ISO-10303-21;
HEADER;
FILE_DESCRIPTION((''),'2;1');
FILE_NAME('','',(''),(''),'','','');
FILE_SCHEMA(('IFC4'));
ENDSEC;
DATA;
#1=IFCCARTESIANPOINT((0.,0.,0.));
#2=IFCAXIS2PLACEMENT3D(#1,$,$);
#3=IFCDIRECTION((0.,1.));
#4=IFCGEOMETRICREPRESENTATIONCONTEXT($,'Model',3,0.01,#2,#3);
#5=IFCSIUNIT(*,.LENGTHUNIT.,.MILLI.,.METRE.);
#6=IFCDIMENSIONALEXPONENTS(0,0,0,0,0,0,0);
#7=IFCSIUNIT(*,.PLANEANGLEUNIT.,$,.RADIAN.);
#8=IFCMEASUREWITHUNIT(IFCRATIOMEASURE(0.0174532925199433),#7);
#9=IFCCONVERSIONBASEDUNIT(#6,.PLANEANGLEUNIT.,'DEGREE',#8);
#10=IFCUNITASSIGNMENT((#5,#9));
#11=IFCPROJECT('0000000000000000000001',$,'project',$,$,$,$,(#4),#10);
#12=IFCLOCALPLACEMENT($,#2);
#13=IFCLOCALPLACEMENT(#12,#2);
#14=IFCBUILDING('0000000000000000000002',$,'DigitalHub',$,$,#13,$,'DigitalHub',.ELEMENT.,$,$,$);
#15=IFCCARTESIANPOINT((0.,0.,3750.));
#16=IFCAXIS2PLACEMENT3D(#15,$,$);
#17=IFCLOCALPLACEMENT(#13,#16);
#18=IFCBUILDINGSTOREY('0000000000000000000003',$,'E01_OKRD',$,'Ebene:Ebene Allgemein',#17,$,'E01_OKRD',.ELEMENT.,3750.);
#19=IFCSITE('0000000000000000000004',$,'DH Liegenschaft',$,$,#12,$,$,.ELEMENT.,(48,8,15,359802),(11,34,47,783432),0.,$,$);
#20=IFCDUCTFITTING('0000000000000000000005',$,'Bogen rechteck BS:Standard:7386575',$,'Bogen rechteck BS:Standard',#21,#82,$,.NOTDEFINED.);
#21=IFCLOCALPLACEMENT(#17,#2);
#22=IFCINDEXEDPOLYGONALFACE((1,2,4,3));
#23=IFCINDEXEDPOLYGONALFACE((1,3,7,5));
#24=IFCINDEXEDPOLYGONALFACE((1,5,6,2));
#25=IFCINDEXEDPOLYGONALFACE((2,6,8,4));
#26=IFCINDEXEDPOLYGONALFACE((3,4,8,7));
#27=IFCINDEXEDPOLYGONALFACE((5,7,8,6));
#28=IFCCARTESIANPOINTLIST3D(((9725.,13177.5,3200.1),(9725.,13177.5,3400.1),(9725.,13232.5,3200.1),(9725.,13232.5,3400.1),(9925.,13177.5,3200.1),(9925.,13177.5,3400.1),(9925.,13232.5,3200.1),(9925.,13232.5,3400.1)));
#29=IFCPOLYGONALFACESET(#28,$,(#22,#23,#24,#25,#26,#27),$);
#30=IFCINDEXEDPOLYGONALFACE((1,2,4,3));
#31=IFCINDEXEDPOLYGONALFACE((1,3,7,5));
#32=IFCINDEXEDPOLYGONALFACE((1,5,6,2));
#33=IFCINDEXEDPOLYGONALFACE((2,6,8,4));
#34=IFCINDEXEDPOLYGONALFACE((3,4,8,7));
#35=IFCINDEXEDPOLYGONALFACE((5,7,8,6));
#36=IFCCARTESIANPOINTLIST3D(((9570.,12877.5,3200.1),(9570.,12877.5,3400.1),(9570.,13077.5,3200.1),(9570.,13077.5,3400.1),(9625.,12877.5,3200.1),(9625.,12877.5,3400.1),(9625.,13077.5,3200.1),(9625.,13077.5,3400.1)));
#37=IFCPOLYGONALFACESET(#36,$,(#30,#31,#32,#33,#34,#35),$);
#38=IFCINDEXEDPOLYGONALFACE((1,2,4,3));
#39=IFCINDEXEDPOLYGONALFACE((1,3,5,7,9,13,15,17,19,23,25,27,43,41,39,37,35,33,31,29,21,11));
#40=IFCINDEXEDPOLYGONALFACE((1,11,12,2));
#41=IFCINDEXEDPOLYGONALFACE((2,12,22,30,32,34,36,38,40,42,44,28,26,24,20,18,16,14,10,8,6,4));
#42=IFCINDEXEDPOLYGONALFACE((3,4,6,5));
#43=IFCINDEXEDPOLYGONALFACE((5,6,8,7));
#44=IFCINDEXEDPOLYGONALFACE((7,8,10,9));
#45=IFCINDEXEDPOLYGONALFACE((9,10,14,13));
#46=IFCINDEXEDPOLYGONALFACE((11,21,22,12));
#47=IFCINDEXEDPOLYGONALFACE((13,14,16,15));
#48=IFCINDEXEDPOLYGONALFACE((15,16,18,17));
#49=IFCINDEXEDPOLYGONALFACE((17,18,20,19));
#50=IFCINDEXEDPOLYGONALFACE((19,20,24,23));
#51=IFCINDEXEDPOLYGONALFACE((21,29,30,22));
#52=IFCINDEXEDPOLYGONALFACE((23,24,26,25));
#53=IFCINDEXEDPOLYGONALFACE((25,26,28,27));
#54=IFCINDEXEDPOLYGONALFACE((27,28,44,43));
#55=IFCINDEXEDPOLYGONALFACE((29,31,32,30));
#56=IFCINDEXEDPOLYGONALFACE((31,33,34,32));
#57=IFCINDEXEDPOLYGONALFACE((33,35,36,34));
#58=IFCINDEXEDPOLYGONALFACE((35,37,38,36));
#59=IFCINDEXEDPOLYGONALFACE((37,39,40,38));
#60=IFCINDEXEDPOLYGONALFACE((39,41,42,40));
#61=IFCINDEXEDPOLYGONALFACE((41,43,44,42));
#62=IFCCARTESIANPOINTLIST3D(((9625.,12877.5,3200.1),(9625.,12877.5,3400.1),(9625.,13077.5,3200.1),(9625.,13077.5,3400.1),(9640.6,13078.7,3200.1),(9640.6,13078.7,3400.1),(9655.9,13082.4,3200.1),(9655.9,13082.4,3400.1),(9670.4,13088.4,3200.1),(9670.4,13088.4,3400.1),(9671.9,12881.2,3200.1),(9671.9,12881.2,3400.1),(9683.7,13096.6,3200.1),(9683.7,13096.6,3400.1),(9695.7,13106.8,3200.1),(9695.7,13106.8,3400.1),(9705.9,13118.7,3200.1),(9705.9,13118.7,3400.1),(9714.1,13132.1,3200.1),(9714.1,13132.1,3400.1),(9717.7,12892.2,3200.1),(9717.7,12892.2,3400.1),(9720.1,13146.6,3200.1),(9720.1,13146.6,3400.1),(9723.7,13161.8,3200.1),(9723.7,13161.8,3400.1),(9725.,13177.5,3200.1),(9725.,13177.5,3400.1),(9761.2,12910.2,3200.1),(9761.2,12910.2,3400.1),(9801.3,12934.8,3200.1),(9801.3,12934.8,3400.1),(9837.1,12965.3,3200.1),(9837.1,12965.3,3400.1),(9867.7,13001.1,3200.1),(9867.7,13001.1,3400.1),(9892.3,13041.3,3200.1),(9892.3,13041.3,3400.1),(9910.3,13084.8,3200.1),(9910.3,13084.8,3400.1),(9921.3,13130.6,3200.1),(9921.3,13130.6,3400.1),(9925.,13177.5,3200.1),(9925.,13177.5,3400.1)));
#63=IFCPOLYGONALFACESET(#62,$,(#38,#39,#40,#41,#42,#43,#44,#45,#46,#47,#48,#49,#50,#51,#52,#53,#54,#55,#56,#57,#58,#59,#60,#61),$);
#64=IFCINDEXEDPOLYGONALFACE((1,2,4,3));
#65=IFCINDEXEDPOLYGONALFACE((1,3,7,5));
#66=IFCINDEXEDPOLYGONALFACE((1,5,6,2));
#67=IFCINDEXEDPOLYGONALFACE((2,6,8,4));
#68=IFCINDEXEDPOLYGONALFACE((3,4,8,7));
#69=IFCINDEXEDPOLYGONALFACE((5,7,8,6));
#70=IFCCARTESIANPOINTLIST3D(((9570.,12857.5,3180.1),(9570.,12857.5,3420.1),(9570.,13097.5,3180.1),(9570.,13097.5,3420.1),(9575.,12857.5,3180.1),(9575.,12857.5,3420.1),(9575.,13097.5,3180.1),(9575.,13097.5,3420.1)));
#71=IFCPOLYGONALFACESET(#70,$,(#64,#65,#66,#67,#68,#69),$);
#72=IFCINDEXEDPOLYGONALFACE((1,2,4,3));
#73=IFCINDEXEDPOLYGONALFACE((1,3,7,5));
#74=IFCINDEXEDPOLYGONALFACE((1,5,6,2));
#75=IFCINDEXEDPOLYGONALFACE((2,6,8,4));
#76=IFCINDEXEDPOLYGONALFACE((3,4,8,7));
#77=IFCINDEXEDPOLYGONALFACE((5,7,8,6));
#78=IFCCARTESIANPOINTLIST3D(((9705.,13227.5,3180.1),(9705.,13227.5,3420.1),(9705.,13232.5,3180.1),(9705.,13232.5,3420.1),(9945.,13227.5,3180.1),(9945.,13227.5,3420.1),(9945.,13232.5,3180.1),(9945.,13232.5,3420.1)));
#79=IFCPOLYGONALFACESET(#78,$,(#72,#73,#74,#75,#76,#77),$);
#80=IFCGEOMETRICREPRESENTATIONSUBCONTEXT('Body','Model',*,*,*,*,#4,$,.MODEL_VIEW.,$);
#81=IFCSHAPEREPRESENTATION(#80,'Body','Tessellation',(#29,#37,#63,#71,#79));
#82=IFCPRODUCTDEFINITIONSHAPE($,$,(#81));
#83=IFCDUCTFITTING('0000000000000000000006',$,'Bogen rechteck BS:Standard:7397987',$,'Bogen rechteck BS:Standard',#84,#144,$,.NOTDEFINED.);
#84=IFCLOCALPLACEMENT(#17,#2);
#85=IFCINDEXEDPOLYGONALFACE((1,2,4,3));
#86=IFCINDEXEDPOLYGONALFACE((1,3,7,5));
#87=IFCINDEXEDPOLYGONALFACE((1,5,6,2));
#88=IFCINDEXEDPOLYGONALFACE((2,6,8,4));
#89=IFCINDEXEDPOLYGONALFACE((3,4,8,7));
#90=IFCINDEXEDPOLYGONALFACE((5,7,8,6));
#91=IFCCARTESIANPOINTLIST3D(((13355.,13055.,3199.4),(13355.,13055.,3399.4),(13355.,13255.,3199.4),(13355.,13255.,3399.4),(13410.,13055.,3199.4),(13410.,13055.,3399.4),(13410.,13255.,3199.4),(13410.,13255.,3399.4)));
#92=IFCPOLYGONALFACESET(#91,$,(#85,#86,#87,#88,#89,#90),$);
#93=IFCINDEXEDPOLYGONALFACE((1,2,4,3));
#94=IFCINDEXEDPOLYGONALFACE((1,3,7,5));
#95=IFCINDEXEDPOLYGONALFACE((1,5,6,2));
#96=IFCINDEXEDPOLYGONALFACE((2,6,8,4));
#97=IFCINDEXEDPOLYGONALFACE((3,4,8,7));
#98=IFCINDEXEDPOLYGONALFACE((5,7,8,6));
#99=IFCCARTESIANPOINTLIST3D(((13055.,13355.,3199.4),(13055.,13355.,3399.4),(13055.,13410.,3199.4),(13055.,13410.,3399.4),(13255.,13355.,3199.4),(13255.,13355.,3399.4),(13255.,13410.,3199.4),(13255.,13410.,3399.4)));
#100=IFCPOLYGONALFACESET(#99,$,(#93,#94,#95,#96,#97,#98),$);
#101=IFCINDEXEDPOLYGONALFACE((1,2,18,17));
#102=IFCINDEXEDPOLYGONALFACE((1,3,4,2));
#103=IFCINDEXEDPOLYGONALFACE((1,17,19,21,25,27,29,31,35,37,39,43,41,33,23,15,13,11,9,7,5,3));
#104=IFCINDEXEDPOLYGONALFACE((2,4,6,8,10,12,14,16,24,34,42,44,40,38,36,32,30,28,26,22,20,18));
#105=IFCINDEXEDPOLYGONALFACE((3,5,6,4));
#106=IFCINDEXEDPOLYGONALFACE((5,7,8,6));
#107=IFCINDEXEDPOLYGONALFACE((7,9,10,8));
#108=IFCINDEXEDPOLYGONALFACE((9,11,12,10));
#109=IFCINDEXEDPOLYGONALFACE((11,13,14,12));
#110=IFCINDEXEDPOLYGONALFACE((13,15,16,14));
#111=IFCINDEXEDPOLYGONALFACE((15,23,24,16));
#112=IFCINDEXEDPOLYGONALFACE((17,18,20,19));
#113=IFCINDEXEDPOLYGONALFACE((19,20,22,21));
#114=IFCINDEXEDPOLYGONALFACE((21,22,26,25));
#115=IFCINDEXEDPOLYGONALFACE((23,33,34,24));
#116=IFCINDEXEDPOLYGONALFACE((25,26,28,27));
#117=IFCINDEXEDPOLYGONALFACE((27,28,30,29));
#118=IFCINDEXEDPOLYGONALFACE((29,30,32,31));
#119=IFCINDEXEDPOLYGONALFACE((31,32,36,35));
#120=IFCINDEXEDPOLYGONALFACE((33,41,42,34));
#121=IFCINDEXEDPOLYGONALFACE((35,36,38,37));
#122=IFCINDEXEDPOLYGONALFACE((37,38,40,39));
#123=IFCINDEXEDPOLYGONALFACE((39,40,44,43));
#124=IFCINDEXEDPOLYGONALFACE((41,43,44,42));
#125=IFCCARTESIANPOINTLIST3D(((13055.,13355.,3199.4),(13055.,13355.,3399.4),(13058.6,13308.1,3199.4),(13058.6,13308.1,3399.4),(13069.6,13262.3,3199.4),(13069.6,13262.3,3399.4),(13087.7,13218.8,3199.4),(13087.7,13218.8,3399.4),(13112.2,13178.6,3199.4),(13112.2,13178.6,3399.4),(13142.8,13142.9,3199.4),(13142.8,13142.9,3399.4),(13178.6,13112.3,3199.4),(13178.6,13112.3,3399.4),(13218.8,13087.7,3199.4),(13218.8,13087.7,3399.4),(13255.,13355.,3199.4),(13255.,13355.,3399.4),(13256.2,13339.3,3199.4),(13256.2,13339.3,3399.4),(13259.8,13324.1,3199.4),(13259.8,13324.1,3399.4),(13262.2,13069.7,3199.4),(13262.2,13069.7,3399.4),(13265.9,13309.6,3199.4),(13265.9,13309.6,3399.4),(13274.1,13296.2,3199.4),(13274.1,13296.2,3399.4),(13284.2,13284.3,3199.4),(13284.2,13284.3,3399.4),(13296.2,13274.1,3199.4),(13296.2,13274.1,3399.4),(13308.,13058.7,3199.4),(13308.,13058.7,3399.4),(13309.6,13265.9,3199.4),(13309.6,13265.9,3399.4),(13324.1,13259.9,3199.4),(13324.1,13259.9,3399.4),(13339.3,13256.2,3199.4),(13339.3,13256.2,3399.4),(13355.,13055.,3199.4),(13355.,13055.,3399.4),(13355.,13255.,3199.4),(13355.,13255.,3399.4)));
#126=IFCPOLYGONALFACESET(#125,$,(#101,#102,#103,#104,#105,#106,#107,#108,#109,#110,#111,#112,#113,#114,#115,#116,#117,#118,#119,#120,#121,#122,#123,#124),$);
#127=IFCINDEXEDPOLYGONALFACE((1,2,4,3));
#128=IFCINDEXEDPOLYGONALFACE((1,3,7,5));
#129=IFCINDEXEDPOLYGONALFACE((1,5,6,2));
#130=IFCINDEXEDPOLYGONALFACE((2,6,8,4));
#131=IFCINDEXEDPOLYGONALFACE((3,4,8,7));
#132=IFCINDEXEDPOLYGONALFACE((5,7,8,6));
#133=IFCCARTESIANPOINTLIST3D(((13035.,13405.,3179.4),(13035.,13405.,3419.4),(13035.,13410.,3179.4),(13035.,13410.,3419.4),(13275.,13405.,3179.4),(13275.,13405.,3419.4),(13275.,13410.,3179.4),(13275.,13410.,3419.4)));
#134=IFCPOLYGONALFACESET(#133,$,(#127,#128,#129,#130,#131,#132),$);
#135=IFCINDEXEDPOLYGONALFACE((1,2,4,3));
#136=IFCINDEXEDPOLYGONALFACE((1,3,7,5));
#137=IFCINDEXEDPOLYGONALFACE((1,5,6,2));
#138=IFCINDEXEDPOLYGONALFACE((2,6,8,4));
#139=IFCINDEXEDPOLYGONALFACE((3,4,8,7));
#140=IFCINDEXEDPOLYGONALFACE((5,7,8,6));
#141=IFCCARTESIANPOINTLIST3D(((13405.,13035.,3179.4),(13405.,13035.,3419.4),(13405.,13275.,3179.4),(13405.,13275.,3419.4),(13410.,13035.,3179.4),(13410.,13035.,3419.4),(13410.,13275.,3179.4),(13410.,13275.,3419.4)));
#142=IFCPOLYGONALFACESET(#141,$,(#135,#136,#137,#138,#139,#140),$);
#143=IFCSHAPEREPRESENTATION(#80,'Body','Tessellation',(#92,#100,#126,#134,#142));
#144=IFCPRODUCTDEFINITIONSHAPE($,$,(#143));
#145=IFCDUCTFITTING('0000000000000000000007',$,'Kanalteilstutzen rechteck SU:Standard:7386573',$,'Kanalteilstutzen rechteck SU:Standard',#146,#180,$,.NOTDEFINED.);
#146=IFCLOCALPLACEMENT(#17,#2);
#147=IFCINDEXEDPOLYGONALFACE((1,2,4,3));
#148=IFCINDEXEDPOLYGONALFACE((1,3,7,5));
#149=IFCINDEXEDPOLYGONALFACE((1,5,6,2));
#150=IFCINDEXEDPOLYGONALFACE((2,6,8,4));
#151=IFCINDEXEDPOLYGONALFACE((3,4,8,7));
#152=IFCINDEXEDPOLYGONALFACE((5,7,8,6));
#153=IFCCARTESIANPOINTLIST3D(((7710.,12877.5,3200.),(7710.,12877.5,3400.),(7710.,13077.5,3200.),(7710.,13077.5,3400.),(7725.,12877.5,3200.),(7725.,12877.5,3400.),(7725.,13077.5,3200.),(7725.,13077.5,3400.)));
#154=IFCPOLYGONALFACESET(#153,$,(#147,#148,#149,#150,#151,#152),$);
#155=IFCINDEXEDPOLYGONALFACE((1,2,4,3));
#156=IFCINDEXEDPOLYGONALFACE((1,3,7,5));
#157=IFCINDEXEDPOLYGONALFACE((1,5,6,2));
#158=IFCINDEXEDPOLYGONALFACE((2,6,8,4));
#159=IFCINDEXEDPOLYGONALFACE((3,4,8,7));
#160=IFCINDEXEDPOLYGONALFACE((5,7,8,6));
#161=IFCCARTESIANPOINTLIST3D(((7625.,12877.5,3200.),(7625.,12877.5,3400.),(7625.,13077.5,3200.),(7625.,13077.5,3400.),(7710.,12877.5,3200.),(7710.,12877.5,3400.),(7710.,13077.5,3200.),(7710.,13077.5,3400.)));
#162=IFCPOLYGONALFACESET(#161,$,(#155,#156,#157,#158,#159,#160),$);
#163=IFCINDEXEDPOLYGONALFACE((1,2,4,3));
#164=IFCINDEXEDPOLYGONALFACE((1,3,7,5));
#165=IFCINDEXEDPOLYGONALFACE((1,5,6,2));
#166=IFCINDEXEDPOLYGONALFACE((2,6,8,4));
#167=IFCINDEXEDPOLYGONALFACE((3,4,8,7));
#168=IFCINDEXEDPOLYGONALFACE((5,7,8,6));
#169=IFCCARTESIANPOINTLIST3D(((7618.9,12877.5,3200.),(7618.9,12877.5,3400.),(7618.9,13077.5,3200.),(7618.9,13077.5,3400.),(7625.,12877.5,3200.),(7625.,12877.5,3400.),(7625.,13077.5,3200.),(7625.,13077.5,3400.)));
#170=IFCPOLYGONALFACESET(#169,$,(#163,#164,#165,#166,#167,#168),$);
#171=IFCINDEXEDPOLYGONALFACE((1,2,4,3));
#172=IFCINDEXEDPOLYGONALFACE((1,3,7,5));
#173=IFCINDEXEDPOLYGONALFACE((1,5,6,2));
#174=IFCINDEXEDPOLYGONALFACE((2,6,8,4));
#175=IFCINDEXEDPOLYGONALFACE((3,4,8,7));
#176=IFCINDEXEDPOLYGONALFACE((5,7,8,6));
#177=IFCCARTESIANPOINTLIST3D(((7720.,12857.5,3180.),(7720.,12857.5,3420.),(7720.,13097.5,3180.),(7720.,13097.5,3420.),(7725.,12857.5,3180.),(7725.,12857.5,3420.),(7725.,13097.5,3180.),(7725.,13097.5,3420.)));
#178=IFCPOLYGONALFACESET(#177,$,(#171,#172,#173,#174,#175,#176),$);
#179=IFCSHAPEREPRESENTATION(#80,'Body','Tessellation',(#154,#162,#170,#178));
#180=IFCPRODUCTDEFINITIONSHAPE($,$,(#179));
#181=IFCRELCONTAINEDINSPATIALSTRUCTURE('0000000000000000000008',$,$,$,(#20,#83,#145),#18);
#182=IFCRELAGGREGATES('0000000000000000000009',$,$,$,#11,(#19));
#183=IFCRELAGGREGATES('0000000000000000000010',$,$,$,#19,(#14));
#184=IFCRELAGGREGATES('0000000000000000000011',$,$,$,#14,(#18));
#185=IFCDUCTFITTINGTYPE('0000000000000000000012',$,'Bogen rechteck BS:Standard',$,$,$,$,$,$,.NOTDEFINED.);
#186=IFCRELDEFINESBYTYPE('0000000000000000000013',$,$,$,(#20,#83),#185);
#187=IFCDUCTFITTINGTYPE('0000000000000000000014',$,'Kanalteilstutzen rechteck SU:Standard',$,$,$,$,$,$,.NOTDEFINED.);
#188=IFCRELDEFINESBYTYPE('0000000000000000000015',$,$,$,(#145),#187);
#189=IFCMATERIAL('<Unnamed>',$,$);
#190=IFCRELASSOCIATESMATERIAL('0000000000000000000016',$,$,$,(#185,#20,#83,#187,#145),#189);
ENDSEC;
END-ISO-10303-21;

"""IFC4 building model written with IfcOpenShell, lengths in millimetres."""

from ifc_helpers import new_model, entity, si_unit, converted_unit, direction, frame, origin, place, context, subcontext, project, spatial, indexed_curve, outline, extrude, source, transform, mapped, material, type_object, type_shapes, element, save


model = new_model("IFC4")

# Units and contexts
model_context = context("Model", 3, precision=0.01, world=origin(), true_north=direction((0.0, 1.0)))
body_context = subcontext(model_context, "Body", "Model", "MODEL_VIEW")
ifc_project = project(units=[si_unit("LENGTHUNIT", "METRE", prefix="MILLI"), converted_unit("PLANEANGLEUNIT", "DEGREE", entity("IfcRatioMeasure", 0.0174532925199433), si_unit("PLANEANGLEUNIT", "RADIAN"), dimensions=[0, 0, 0, 0, 0, 0, 0])], contexts=[model_context])

# Site, building, storey
site_placement = place(None, origin())
site = spatial("IfcSite", under=ifc_project, at=site_placement, Name="DH Liegenschaft", CompositionType="ELEMENT", RefLatitude=(48, 8, 15, 359802), RefLongitude=(11, 34, 47, 783432), RefElevation=0.0)
building_placement = place(site_placement, origin())
building = spatial("IfcBuilding", under=site, at=building_placement, Name="DigitalHub", LongName="DigitalHub", CompositionType="ELEMENT")
storey_placement = place(building_placement, frame((0.0, 0.0, 3750.0)))
storey = spatial("IfcBuildingStorey", under=building, at=storey_placement, Name="E01_OKRD", ObjectType="Ebene:Ebene Allgemein", LongName="E01_OKRD", CompositionType="ELEMENT", Elevation=3750.0)

# Shared definitions
ifc_material_1 = material(Name="<Unnamed>")

# Duct fittings
duct_fitting_type_1 = type_object("IfcDuctFittingType", Name="Bogen rechteck BS:Standard", PredefinedType="NOTDEFINED", material=ifc_material_1)
shared_shape_1 = source(origin(), body_context, "Body", "SweptSolid", [
    extrude(outline(indexed_curve([(-27.5, -100.0), (27.5, -100.0), (27.5, 100.0), (-27.5, 100.0), (-27.5, -100.0)], self_intersect=False)), frame((0.0, 227.5, -100.0), z_axis=(0.0, 0.0, 1.0), x_axis=(0.0, 1.0, 0.0)), (0.0, 0.0, 1.0), 200.0),
    extrude(outline(indexed_curve([(-100.0, -27.5), (100.0, -27.5), (100.0, 27.5), (-100.0, 27.5), (-100.0, -27.5)], self_intersect=False)), frame((-227.5, 0.0, -100.0), z_axis=(0.0, 0.0, 1.0), x_axis=(0.0, -1.0, 0.0)), (0.0, 0.0, 1.0), 200.0),
    extrude(outline(indexed_curve([(-200.0, -100.0), (0.0, -100.0), (1.2, -84.4), (4.9, -69.1), (10.9, -54.6), (19.1, -41.2), (29.3, -29.3), (41.2, -19.1), (54.6, -10.9), (69.1, -4.9), (84.4, -1.2), (100.0, 0.0), (100.0, 200.0), (53.1, 196.3), (7.3, 185.3), (-36.2, 167.3), (-76.3, 142.7), (-112.1, 112.1), (-142.7, 76.3), (-167.3, 36.2), (-185.3, -7.3), (-196.3, -53.1), (-200.0, -100.0)], self_intersect=False)), frame((-100.0, 100.0, -100.0), z_axis=(0.0, 0.0, 1.0), x_axis=(-1.0, 0.0, 0.0)), (0.0, 0.0, 1.0), 200.0),
    extrude(outline(indexed_curve([(-2.5, -120.0), (2.5, -120.0), (2.5, 120.0), (-2.5, 120.0), (-2.5, -120.0)], self_intersect=False)), frame((-252.5, 0.0, -120.0)), (0.0, 0.0, 1.0), 240.0),
    extrude(outline(indexed_curve([(-2.5, -120.0), (2.5, -120.0), (2.5, 120.0), (-2.5, 120.0), (-2.5, -120.0)], self_intersect=False)), frame((0.0, 252.5, -120.0), z_axis=(0.0, 0.0, 1.0), x_axis=(0.0, 1.0, 0.0)), (0.0, 0.0, 1.0), 240.0),
])
type_shapes(duct_fitting_type_1, [shared_shape_1])
duct_fitting_1_placement = place(storey_placement, frame((9825.0, 12977.5, 3300.1)))
element("IfcDuctFitting", 1, at=duct_fitting_1_placement, inside=storey, type_object=duct_fitting_type_1, material=ifc_material_1, Name="Bogen rechteck BS:Standard:7386575", ObjectType="Bogen rechteck BS:Standard", PredefinedType="NOTDEFINED", context=body_context, shape_type="MappedRepresentation", body=[
    mapped(shared_shape_1, transform((0.0, 0.0, 0.0), scale=1.0)),
])
duct_fitting_2_placement = place(storey_placement, frame((13155.0, 13155.0, 3299.4), z_axis=(0.0, 0.0, 1.0), x_axis=(0.0, -1.0, 0.0)))
element("IfcDuctFitting", 2, at=duct_fitting_2_placement, inside=storey, type_object=duct_fitting_type_1, material=ifc_material_1, Name="Bogen rechteck BS:Standard:7397987", ObjectType="Bogen rechteck BS:Standard", PredefinedType="NOTDEFINED", context=body_context, shape_type="MappedRepresentation", body=[
    mapped(shared_shape_1, transform((0.0, 0.0, 0.0), scale=1.0)),
])
duct_fitting_type_2 = type_object("IfcDuctFittingType", Name="Kanalteilstutzen rechteck SU:Standard", PredefinedType="NOTDEFINED", material=ifc_material_1)
shared_shape_2 = source(origin(), body_context, "Body", "SweptSolid", [
    extrude(outline(indexed_curve([(-100.0, -7.5), (100.0, -7.5), (100.0, 7.5), (-100.0, 7.5), (-100.0, -7.5)], self_intersect=False)), frame((92.5, 0.0, -100.0), z_axis=(0.0, 0.0, 1.0), x_axis=(0.0, -1.0, 0.0)), (0.0, 0.0, 1.0), 200.0),
    extrude(outline(indexed_curve([(-100.0, -42.5), (100.0, -42.5), (100.0, 42.5), (-100.0, 42.5), (-100.0, -42.5)], self_intersect=False)), frame((42.5, 0.0, -100.0), z_axis=(0.0, 0.0, 1.0), x_axis=(0.0, -1.0, 0.0)), (0.0, 0.0, 1.0), 200.0),
    extrude(outline(indexed_curve([(-100.0, -3.0), (100.0, -3.0), (100.0, 3.0), (-100.0, 3.0), (-100.0, -3.0)], self_intersect=False)), frame((-3.0, 0.0, -100.0), z_axis=(0.0, 0.0, 1.0), x_axis=(0.0, -1.0, 0.0)), (0.0, 0.0, 1.0), 200.0),
    extrude(outline(indexed_curve([(-120.0, -2.5), (120.0, -2.5), (120.0, 2.5), (-120.0, 2.5), (-120.0, -2.5)], self_intersect=False)), frame((97.5, 0.0, -120.0), z_axis=(0.0, 0.0, 1.0), x_axis=(0.0, -1.0, 0.0)), (0.0, 0.0, 1.0), 240.0),
])
type_shapes(duct_fitting_type_2, [shared_shape_2])
duct_fitting_3_placement = place(storey_placement, frame((7625.0, 12977.5, 3300.0), z_axis=(0.0, 0.0, -1.0), x_axis=(1.0, 0.0, 0.0)))
element("IfcDuctFitting", 3, at=duct_fitting_3_placement, inside=storey, type_object=duct_fitting_type_2, material=ifc_material_1, Name="Kanalteilstutzen rechteck SU:Standard:7386573", ObjectType="Kanalteilstutzen rechteck SU:Standard", PredefinedType="NOTDEFINED", context=body_context, shape_type="MappedRepresentation", body=[
    mapped(shared_shape_2, transform((0.0, 0.0, 0.0), scale=1.0)),
])

save(model, "model.ifc")
